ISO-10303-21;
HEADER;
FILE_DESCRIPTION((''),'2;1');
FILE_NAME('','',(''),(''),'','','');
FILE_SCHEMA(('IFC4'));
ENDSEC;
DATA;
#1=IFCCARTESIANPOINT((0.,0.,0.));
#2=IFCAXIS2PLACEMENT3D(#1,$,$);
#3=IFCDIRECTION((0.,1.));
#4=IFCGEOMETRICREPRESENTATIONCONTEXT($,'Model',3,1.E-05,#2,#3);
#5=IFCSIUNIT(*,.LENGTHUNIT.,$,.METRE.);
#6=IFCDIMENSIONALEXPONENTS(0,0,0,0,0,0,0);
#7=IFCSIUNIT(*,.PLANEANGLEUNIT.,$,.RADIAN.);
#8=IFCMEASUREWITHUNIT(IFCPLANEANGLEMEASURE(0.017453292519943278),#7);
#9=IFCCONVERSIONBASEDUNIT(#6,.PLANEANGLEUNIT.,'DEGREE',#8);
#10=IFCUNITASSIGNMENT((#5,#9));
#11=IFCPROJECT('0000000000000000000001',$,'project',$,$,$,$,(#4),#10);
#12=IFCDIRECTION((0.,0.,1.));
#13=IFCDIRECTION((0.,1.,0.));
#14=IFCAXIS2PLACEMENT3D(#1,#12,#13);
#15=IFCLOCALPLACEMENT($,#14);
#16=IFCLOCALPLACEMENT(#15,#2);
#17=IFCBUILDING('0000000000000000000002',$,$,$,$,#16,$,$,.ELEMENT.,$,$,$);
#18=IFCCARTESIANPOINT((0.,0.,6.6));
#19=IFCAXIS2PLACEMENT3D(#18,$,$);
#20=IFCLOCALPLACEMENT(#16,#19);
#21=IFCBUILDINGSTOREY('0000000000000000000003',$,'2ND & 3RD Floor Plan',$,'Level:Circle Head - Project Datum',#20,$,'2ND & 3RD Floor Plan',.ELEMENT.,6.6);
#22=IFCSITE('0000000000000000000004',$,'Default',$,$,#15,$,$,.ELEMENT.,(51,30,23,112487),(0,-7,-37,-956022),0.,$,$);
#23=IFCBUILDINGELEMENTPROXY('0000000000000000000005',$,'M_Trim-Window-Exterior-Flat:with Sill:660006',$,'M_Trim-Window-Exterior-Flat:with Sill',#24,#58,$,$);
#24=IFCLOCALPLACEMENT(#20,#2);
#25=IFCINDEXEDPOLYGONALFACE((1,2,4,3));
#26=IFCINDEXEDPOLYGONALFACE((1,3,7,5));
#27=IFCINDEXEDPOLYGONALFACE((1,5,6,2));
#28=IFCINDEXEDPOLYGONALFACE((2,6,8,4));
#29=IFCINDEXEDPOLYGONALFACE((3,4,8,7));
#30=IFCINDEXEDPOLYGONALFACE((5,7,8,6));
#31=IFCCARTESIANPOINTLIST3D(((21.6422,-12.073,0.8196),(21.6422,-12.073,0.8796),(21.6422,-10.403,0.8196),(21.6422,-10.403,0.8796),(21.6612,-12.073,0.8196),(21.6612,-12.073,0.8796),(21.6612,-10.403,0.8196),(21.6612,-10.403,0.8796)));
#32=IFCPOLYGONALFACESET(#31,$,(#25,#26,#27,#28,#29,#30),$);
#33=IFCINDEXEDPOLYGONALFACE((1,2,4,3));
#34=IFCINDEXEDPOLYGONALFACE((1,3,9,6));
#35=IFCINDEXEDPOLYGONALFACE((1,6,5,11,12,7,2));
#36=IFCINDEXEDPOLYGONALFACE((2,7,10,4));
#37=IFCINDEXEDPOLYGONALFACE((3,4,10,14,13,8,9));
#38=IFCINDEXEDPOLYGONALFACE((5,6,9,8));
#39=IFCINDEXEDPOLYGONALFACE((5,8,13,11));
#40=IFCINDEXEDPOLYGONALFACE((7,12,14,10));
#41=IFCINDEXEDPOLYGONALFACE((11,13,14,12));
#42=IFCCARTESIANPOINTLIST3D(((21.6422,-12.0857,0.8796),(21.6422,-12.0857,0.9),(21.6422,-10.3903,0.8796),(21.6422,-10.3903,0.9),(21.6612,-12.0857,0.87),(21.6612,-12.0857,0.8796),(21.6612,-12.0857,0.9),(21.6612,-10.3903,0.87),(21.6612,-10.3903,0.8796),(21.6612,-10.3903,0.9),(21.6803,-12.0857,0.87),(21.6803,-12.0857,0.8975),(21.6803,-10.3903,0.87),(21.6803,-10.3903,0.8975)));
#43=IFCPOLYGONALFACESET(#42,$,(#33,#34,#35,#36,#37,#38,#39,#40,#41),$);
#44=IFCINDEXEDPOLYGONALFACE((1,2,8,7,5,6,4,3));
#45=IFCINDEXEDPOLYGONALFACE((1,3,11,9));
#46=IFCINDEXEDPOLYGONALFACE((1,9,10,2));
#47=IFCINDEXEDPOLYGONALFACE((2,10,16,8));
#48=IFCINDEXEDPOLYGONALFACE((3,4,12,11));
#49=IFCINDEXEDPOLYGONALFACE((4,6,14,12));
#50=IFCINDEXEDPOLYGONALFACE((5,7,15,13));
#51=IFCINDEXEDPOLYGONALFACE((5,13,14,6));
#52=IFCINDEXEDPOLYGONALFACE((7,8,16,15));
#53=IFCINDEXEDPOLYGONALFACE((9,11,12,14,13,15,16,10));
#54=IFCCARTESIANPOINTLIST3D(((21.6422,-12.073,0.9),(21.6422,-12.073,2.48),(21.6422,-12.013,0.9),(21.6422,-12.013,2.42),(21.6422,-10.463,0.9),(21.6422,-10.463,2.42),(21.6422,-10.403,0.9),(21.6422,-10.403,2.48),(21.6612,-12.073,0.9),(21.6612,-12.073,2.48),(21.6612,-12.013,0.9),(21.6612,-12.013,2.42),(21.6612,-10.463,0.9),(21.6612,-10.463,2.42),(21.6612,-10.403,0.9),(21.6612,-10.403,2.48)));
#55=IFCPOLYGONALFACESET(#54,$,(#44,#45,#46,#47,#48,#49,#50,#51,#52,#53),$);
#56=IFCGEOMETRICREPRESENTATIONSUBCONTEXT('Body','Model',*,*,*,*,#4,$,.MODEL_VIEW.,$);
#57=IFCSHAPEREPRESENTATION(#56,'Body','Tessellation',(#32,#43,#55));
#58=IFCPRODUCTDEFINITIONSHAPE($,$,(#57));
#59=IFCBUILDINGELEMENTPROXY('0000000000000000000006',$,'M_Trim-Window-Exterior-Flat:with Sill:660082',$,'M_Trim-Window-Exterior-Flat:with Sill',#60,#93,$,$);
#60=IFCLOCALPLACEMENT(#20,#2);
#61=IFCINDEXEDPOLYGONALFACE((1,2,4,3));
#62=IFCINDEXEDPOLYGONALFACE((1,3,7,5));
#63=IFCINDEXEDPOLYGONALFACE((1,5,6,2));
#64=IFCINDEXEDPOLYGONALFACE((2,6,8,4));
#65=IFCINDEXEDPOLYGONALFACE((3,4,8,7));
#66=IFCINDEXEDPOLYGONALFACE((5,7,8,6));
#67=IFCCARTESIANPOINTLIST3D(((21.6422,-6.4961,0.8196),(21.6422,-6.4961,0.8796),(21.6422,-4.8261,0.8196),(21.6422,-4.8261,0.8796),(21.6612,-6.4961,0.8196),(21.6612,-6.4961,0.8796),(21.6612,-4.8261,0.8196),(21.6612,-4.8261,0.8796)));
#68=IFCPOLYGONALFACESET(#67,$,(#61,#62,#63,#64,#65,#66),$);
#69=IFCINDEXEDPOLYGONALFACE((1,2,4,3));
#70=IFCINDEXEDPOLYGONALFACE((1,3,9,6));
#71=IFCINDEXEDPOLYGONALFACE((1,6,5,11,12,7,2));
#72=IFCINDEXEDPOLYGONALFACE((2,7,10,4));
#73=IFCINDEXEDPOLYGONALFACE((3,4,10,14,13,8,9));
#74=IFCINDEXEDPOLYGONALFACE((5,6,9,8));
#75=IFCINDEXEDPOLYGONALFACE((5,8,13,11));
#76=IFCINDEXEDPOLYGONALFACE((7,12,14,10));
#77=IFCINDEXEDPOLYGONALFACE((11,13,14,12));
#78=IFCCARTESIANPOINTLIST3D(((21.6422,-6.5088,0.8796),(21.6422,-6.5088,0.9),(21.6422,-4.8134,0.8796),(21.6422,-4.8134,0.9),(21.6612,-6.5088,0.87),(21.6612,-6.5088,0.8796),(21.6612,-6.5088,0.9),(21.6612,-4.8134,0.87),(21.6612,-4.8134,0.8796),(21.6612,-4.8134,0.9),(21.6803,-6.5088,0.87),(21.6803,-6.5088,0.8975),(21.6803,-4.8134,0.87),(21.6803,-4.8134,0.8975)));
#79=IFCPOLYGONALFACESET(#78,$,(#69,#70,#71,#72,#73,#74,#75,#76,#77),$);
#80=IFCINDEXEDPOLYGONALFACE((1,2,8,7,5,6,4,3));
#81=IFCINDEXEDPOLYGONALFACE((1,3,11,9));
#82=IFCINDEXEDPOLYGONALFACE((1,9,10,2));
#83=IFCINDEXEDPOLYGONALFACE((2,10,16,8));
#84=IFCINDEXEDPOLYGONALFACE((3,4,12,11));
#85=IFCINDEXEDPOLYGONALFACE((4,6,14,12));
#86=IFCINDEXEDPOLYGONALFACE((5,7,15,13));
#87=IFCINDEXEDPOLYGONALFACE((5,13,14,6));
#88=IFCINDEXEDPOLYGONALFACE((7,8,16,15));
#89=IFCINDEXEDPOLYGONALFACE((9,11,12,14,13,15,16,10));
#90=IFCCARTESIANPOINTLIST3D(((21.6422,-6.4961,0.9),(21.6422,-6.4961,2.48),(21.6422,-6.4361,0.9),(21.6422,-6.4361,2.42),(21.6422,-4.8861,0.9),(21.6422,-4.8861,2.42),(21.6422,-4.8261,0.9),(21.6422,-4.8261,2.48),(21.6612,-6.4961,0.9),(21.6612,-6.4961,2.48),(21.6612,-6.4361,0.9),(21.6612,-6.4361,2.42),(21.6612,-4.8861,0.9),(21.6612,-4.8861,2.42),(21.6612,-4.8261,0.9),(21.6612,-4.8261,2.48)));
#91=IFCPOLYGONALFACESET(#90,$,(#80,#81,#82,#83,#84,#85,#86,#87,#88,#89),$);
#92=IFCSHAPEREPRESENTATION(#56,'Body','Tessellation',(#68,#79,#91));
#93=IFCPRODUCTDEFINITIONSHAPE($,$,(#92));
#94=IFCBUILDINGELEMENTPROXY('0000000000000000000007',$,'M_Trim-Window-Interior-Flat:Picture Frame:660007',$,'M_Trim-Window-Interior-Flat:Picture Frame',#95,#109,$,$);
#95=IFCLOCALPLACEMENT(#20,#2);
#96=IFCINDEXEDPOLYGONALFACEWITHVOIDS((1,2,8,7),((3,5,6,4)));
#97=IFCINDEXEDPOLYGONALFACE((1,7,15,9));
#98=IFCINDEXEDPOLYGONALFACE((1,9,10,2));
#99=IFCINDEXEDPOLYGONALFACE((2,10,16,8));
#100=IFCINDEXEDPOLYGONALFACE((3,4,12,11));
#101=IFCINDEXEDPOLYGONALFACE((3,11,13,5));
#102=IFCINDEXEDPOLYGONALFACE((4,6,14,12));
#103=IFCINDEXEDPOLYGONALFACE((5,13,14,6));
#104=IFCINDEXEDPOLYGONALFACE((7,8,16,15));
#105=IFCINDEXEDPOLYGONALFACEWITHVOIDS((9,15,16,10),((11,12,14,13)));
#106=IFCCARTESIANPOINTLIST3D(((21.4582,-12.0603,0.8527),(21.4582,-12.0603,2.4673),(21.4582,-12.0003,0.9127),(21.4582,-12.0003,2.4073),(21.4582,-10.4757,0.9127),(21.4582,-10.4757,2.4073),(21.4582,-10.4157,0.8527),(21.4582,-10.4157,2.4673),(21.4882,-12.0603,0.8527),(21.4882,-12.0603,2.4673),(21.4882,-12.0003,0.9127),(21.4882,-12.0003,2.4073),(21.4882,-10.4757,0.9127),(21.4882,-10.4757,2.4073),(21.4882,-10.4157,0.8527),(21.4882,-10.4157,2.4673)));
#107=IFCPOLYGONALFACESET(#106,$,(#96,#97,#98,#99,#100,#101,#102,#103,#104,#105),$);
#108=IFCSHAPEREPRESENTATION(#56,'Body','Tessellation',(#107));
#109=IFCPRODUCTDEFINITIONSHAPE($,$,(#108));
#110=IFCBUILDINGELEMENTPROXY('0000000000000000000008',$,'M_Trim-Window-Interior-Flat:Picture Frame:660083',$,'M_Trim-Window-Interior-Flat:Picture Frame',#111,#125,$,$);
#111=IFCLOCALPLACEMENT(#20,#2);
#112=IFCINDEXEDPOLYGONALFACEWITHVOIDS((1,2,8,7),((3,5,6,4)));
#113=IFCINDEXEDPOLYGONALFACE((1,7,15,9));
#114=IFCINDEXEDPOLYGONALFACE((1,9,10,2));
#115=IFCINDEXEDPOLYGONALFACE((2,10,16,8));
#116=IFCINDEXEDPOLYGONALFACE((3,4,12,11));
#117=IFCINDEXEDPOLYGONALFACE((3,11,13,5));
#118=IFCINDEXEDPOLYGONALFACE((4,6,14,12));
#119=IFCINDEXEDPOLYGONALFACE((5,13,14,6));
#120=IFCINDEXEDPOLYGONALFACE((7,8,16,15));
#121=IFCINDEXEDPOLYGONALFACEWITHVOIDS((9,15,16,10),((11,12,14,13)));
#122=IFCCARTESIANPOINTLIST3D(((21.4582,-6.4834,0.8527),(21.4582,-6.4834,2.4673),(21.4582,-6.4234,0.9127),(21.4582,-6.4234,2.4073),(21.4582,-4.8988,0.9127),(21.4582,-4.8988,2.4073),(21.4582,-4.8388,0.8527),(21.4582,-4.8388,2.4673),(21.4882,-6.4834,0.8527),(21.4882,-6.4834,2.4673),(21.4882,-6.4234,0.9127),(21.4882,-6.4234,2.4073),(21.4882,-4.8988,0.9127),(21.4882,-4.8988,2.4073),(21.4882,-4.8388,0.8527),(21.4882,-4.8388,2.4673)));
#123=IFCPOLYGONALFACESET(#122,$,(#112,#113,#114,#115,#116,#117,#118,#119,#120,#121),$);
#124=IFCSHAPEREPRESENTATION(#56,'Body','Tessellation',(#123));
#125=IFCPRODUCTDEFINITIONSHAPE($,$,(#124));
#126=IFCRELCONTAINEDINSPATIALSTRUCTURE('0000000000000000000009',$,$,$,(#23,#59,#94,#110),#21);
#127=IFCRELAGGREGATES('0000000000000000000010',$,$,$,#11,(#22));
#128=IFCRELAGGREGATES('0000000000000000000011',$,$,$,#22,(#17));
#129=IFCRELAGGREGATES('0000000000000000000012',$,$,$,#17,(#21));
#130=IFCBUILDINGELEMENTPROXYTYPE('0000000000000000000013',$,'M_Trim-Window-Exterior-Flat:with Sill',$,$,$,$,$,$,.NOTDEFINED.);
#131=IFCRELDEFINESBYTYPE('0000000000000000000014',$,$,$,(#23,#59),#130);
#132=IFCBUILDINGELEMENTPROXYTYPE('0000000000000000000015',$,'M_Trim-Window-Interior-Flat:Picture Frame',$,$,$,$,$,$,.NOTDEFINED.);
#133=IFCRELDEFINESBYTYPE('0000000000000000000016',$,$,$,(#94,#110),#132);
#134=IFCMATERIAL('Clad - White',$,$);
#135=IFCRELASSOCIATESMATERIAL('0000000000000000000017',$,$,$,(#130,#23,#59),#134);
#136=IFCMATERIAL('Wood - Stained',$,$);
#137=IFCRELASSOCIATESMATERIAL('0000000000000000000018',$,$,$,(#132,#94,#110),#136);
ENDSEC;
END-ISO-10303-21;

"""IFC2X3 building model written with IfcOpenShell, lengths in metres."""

from ifc_helpers import new_model, entity, si_unit, converted_unit, direction, frame, frame_2d, origin, place, context, subcontext, project, spatial, polyline, rectangle, outline, extrude, source, transform, mapped, material, type_object, type_shapes, element, save


model = new_model("IFC2X3")

# Units and contexts
model_context = context("Model", 3, precision=1e-05, world=origin(), true_north=direction((0.0, 1.0)))
body_context = subcontext(model_context, "Body", "Model", "MODEL_VIEW")
ifc_project = project(units=[si_unit("LENGTHUNIT", "METRE"), converted_unit("PLANEANGLEUNIT", "DEGREE", entity("IfcPlaneAngleMeasure", 0.017453292519943278), si_unit("PLANEANGLEUNIT", "RADIAN"), dimensions=[0, 0, 0, 0, 0, 0, 0])], contexts=[model_context])

# Site, building, storey
site_placement = place(None, frame((0.0, 0.0, 0.0), z_axis=(0.0, 0.0, 1.0), x_axis=(0.0, 1.0, 0.0)))
site = spatial("IfcSite", under=ifc_project, at=site_placement, Name="Default", CompositionType="ELEMENT", RefLatitude=(51, 30, 23, 112487), RefLongitude=(0, -7, -37, -956022), RefElevation=0.0)
building_placement = place(site_placement, origin())
building = spatial("IfcBuilding", under=site, at=building_placement, CompositionType="ELEMENT")
storey_placement = place(building_placement, frame((0.0, 0.0, 6.6)))
storey = spatial("IfcBuildingStorey", under=building, at=storey_placement, Name="2ND & 3RD Floor Plan", ObjectType="Level:Circle Head - Project Datum", LongName="2ND & 3RD Floor Plan", CompositionType="ELEMENT", Elevation=6.6)

# Building element proxies
ifc_material_1 = material(Name="Clad - White")
ifc_material_2 = material(Name="Wood - Stained")
building_element_proxy_type_1 = type_object("IfcBuildingElementProxyType", Name="M_Trim-Window-Exterior-Flat:with Sill", PredefinedType="NOTDEFINED", material=ifc_material_1)
shared_shape_1 = source(origin(), body_context, "Body", "SweptSolid", [
    extrude(rectangle(XDim=1.67, YDim=0.06, at=frame_2d((0.0, 0.0), x_axis=(1.0, 0.0))), frame((0.0, -1.5704, 0.0), z_axis=(0.0, 0.0, 1.0), x_axis=(-1.0, 0.0, 0.0)), (0.0, 0.0, 1.0), 0.019),
    extrude(outline(polyline([(-0.019, -0.0152), (0.0, -0.0152), (0.0, -0.0057), (0.019, -0.0057), (0.019, 0.0148), (0.0, 0.0148), (-0.019, 0.0123), (-0.019, -0.0152)])), frame((-0.8477, -1.5348, 0.019), z_axis=(1.0, 0.0, 0.0), x_axis=(0.0, 0.0, -1.0)), (0.0, 0.0, 1.0), 1.6954),
    extrude(outline(polyline([(-0.805, -0.835), (0.775, -0.835), (0.775, -0.775), (-0.745, -0.775), (-0.745, 0.775), (0.775, 0.775), (0.775, 0.835), (-0.805, 0.835), (-0.805, -0.835)])), frame((0.0, -0.745, 0.0), z_axis=(0.0, 0.0, 1.0), x_axis=(0.0, -1.0, 0.0)), (0.0, 0.0, 1.0), 0.019),
])
type_shapes(building_element_proxy_type_1, [shared_shape_1])
for number, where, z_axis, x_axis, name in (
    (1, (21.6422, -11.238, 2.42), (1.0, 0.0, 0.0), (0.0, 1.0, 0.0), "M_Trim-Window-Exterior-Flat:with Sill:660006"),
    (2, (21.6422, -5.6611, 2.42), (1.0, 0.0, 0.0), (0.0, 1.0, 0.0), "M_Trim-Window-Exterior-Flat:with Sill:660082"),
):
    element("IfcBuildingElementProxy", number, at=place(storey_placement, frame(where, z_axis=z_axis, x_axis=x_axis)), inside=storey, type_object=building_element_proxy_type_1, material=ifc_material_1, Name=name, ObjectType="M_Trim-Window-Exterior-Flat:with Sill", context=body_context, shape_type="MappedRepresentation", body=[
        mapped(shared_shape_1, transform((0.0, 0.0, 0.0), scale=1.0)),
    ])
building_element_proxy_type_2 = type_object("IfcBuildingElementProxyType", Name="M_Trim-Window-Interior-Flat:Picture Frame", PredefinedType="NOTDEFINED", material=ifc_material_2)
shared_shape_2 = source(origin(), body_context, "Body", "SweptSolid", [
    extrude(outline(polyline([(-0.8223, -0.8073), (0.8223, -0.8073), (0.8223, 0.8073), (-0.8223, 0.8073), (-0.8223, -0.8073)]), holes=[polyline([(-0.7623, -0.7473), (-0.7623, 0.7473), (0.7623, 0.7473), (0.7623, -0.7473), (-0.7623, -0.7473)])]), frame((0.0, -0.76, 0.0), z_axis=(0.0, 0.0, 1.0), x_axis=(-1.0, 0.0, 0.0)), (0.0, 0.0, 1.0), 0.03),
])
type_shapes(building_element_proxy_type_2, [shared_shape_2])
for number, where, z_axis, x_axis, name in (
    (3, (21.4882, -11.238, 2.42), (-1.0, 0.0, 0.0), (0.0, -1.0, 0.0), "M_Trim-Window-Interior-Flat:Picture Frame:660007"),
    (4, (21.4882, -5.6611, 2.42), (-1.0, 0.0, 0.0), (0.0, -1.0, 0.0), "M_Trim-Window-Interior-Flat:Picture Frame:660083"),
):
    element("IfcBuildingElementProxy", number, at=place(storey_placement, frame(where, z_axis=z_axis, x_axis=x_axis)), inside=storey, type_object=building_element_proxy_type_2, material=ifc_material_2, Name=name, ObjectType="M_Trim-Window-Interior-Flat:Picture Frame", context=body_context, shape_type="MappedRepresentation", body=[
        mapped(shared_shape_2, transform((0.0, 0.0, 0.0), scale=1.0)),
    ])

save(model, "model.ifc")
